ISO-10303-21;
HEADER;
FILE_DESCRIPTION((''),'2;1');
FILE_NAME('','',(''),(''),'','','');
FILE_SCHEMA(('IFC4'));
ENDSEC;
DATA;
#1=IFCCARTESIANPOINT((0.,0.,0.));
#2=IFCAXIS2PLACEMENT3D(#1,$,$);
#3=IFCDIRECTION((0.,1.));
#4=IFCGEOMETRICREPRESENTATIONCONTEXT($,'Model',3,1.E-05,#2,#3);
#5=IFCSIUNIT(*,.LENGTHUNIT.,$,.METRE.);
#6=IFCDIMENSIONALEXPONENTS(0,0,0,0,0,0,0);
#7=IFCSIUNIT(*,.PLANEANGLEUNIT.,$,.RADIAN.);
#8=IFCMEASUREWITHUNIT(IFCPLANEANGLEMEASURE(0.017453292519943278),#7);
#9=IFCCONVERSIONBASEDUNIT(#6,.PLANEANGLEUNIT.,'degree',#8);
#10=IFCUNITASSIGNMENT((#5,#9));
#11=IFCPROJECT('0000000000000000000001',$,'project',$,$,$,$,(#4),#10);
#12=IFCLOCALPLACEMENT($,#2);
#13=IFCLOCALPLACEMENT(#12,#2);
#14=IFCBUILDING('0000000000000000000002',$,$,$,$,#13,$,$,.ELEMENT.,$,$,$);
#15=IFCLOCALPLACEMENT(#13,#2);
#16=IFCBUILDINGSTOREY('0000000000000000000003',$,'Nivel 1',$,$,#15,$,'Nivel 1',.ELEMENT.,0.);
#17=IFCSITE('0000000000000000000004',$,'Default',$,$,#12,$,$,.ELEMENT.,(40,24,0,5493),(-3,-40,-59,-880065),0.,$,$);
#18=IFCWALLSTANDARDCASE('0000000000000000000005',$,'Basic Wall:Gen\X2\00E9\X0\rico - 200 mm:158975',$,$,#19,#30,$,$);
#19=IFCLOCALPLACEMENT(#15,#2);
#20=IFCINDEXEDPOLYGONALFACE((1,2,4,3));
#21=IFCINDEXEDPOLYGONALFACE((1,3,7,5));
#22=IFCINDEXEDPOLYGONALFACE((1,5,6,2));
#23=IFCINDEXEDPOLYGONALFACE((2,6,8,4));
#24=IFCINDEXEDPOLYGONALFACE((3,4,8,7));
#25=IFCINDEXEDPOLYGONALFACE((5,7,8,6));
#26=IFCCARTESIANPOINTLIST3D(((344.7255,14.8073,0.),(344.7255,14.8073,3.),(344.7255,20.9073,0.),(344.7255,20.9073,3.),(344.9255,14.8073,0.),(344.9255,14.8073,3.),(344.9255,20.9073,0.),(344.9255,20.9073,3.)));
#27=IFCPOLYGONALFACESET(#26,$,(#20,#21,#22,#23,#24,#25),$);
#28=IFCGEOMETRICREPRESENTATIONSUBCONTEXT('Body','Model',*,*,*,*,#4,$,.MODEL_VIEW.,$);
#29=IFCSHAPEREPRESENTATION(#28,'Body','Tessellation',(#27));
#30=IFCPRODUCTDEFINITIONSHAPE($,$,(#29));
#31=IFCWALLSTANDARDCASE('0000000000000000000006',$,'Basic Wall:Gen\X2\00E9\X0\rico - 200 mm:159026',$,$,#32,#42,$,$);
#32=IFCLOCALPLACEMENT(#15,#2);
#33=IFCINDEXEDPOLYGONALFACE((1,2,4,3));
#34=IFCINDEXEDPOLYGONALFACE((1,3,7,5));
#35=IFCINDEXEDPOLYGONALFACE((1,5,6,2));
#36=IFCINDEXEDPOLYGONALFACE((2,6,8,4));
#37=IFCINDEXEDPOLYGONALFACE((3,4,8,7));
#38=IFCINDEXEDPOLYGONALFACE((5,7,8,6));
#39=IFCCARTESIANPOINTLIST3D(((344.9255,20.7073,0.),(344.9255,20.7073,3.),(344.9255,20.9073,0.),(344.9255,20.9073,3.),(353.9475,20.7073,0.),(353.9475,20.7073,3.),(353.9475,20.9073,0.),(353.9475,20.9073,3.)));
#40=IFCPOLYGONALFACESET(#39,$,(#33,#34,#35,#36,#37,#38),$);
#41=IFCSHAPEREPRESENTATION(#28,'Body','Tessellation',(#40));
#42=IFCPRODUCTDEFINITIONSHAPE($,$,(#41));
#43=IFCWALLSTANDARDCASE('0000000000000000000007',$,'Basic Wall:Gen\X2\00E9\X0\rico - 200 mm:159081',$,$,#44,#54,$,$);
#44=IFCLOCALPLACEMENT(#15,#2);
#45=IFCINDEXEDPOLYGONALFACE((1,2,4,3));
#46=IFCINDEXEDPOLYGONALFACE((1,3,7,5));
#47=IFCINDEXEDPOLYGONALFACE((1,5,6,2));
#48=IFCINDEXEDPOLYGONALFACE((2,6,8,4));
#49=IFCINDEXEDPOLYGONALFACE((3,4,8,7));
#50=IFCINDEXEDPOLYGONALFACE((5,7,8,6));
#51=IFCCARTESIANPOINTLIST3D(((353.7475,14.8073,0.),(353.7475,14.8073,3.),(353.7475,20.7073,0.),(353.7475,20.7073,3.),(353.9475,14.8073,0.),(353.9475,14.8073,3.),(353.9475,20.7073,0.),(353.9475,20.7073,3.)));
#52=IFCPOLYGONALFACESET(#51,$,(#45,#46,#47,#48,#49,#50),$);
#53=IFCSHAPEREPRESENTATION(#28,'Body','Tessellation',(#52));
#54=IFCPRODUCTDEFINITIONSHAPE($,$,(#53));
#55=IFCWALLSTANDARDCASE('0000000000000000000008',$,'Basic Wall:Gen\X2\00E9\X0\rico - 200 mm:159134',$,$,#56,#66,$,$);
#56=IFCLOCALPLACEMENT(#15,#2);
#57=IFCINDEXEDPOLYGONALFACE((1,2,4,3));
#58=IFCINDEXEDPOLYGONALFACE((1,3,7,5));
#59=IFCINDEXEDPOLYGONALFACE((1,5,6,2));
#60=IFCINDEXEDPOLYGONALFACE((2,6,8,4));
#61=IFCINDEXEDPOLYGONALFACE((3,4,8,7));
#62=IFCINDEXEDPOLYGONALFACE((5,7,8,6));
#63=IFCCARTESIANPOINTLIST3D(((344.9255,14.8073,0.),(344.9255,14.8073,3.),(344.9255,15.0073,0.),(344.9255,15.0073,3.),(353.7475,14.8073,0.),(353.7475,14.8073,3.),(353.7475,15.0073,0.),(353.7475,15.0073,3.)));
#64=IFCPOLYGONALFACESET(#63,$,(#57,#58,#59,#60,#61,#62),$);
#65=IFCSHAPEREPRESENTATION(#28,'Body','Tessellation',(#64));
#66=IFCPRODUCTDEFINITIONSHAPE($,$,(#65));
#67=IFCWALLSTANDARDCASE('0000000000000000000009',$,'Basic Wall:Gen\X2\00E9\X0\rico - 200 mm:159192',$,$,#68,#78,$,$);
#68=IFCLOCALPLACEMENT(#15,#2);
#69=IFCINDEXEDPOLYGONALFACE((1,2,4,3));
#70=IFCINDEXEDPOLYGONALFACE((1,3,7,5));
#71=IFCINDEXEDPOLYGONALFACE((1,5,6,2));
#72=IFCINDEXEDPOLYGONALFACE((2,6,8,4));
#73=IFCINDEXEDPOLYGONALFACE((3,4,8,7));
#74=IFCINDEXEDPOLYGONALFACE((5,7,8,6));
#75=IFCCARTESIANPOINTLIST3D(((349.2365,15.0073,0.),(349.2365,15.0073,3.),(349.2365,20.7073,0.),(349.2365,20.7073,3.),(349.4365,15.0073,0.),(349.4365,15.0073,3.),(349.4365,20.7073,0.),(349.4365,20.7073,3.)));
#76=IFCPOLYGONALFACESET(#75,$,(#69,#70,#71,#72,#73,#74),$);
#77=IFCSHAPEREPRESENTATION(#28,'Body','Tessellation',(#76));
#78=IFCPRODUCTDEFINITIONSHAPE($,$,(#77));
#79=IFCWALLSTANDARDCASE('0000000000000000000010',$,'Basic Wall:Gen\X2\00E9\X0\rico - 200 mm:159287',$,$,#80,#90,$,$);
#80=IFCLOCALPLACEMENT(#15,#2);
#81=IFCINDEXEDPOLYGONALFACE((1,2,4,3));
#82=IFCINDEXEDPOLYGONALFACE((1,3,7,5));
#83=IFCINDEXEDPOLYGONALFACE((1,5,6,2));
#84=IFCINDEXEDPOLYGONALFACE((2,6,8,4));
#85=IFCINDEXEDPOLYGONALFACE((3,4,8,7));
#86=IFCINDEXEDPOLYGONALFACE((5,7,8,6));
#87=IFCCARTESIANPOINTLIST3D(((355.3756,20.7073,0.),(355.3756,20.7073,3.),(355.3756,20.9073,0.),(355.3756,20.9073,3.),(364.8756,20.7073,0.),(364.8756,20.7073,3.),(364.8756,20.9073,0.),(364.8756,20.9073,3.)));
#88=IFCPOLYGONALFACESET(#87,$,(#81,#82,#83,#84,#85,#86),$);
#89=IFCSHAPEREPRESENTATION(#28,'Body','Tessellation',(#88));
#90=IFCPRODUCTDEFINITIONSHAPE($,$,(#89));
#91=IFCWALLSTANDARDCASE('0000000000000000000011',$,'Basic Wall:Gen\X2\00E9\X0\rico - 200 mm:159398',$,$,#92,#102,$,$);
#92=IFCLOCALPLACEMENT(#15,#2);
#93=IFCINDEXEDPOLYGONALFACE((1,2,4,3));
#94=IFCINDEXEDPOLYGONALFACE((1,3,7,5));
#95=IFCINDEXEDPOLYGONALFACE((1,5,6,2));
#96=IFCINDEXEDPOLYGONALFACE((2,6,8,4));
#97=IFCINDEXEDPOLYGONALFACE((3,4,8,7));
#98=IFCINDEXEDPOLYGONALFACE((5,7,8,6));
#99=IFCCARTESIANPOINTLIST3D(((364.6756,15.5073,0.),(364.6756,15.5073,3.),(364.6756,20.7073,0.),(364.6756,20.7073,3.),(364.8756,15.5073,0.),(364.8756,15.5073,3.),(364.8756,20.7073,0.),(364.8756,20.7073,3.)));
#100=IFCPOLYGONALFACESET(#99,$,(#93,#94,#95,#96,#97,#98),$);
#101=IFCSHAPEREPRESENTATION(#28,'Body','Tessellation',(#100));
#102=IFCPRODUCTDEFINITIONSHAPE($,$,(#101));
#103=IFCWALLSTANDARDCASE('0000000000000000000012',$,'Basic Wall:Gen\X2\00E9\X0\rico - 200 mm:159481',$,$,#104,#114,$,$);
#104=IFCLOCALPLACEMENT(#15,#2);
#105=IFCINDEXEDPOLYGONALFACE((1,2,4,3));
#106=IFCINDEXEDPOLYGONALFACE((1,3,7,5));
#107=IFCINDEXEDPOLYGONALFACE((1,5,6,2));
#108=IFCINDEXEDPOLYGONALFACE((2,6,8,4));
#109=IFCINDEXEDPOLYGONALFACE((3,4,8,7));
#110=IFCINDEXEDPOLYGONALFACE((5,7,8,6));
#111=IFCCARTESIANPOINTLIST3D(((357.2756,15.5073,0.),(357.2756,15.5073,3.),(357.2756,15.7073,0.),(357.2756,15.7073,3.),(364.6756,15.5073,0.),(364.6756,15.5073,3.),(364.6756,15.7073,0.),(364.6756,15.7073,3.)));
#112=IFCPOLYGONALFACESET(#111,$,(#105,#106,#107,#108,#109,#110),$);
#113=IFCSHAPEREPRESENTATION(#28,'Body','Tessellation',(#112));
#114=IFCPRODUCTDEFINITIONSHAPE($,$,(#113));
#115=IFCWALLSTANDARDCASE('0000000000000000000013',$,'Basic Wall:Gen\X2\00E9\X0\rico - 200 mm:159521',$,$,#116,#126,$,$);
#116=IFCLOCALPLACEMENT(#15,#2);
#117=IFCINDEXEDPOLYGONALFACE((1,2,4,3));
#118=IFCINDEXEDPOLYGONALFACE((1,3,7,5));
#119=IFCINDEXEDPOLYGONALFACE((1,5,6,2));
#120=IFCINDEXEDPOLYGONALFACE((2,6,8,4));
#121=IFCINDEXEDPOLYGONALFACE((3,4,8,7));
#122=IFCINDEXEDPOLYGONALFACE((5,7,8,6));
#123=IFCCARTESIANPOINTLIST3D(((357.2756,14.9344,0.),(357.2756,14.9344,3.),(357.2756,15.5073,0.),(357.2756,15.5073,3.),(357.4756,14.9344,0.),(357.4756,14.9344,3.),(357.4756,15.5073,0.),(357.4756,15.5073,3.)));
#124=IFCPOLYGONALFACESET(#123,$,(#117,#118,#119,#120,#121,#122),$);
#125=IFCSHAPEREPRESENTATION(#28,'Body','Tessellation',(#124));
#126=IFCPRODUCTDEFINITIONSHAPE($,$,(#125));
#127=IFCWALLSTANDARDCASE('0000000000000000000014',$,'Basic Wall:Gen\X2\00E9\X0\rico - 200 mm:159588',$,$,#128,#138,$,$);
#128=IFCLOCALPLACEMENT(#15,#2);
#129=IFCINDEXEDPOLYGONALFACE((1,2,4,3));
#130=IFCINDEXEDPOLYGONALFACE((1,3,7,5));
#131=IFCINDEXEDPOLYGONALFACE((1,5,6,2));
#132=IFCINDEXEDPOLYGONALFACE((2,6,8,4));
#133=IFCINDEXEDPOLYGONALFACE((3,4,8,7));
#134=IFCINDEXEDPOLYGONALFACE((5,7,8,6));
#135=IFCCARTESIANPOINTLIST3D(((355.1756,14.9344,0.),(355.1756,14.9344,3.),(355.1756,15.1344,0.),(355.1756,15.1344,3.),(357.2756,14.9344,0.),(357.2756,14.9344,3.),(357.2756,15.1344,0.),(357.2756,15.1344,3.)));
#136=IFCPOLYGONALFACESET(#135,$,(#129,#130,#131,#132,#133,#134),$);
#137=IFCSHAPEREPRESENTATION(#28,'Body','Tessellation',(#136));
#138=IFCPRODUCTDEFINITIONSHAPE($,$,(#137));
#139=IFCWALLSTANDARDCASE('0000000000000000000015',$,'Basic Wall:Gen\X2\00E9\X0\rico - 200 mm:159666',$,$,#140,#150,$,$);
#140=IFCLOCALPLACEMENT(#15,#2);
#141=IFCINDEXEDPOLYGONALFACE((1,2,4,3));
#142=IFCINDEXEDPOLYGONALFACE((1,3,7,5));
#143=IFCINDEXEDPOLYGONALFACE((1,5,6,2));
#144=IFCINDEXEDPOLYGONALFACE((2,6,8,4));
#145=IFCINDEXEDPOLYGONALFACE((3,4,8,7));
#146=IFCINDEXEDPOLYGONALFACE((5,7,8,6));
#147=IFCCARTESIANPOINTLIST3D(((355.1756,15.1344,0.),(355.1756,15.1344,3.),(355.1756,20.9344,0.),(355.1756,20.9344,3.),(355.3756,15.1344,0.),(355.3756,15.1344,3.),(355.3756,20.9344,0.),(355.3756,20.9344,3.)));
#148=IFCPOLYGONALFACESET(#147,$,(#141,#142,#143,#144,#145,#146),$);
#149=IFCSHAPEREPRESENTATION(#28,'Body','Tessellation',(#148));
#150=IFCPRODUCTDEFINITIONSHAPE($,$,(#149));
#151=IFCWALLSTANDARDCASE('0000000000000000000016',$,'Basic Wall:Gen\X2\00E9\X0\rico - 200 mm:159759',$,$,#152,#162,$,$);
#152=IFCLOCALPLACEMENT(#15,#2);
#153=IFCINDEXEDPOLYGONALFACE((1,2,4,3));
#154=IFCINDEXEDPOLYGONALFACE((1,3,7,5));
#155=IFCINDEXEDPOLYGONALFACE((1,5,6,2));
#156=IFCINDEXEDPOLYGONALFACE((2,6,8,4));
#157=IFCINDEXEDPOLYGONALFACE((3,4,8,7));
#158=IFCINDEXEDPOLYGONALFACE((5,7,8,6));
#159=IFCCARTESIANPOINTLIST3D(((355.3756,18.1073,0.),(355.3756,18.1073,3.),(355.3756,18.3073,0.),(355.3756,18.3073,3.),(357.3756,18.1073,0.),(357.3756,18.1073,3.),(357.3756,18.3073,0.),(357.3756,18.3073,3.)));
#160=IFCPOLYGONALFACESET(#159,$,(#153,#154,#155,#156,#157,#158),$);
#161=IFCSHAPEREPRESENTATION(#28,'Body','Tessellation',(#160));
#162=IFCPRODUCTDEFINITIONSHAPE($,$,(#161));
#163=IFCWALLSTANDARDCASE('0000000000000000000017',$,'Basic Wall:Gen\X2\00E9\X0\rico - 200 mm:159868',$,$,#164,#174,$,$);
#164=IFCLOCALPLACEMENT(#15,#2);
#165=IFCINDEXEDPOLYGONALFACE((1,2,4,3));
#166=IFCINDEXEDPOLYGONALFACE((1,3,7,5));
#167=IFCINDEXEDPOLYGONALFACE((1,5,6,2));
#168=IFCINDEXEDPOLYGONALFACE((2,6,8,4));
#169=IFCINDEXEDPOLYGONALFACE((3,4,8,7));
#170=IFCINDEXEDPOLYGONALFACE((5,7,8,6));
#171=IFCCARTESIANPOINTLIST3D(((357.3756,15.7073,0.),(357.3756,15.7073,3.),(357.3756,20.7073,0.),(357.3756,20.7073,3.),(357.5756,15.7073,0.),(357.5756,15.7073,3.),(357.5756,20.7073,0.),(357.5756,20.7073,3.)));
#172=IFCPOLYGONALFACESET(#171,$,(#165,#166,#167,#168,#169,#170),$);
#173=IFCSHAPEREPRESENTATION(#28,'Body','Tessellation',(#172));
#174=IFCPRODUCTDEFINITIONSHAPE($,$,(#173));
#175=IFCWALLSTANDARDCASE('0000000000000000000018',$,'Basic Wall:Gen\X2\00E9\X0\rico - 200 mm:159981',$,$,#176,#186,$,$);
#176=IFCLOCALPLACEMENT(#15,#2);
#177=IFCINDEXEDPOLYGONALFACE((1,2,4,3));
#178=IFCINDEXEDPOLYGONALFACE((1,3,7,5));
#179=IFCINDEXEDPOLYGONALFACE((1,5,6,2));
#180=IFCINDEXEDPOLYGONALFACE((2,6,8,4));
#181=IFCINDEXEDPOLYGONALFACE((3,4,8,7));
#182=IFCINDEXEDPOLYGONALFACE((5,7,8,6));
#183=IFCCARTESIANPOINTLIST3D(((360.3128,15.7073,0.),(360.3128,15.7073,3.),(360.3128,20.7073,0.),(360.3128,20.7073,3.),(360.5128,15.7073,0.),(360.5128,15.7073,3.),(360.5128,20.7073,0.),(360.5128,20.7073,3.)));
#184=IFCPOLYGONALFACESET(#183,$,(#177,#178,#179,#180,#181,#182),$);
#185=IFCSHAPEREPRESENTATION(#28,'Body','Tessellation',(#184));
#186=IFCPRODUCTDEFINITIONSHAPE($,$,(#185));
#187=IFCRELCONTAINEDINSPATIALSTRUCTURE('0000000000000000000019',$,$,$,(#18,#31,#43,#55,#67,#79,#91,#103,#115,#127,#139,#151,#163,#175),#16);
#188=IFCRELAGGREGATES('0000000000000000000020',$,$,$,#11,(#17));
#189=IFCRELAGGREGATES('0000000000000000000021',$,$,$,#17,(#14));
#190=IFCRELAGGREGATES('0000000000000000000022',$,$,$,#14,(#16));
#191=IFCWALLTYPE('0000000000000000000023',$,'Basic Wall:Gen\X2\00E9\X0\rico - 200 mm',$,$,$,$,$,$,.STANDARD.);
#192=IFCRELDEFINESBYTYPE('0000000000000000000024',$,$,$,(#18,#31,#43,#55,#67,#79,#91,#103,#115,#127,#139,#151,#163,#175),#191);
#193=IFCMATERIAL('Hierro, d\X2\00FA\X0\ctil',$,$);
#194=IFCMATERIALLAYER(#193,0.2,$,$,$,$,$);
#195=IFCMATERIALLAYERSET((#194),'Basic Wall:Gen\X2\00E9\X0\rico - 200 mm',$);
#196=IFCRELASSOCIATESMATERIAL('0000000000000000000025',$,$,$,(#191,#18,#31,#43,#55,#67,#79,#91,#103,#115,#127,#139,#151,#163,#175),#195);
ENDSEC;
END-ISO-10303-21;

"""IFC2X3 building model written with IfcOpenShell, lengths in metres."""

from ifc_helpers import new_model, entity, si_unit, converted_unit, direction, frame, frame_2d, origin, place, context, subcontext, project, spatial, rectangle, extrude, material, layer, layer_set, layer_usage, type_object, element, save


model = new_model("IFC2X3")

# Units and contexts
model_context = context("Model", 3, precision=1e-05, world=origin(), true_north=direction((0.0, 1.0)))
body_context = subcontext(model_context, "Body", "Model", "MODEL_VIEW")
ifc_project = project(units=[si_unit("LENGTHUNIT", "METRE"), converted_unit("PLANEANGLEUNIT", "degree", entity("IfcPlaneAngleMeasure", 0.017453292519943278), si_unit("PLANEANGLEUNIT", "RADIAN"), dimensions=[0, 0, 0, 0, 0, 0, 0])], contexts=[model_context])

# Site, building, storey
site_placement = place(None, origin())
site = spatial("IfcSite", under=ifc_project, at=site_placement, Name="Default", CompositionType="ELEMENT", RefLatitude=(40, 24, 0, 5493), RefLongitude=(-3, -40, -59, -880065), RefElevation=0.0)
building_placement = place(site_placement, origin())
building = spatial("IfcBuilding", under=site, at=building_placement, CompositionType="ELEMENT")
storey_placement = place(building_placement, origin())
storey = spatial("IfcBuildingStorey", under=building, at=storey_placement, Name="Nivel 1", LongName="Nivel 1", CompositionType="ELEMENT", Elevation=0.0)

# Walls
ifc_material_1 = material(Name="Hierro, dúctil")
ifc_layer_1 = layer(ifc_material_1, 0.2)
ifc_layer_set_1 = layer_set([ifc_layer_1], Name="Basic Wall:Genérico - 200 mm")
ifc_layer_usage_1 = layer_usage(ifc_layer_set_1, "AXIS2", "NEGATIVE", 0.1)
wall_type = type_object("IfcWallType", Name="Basic Wall:Genérico - 200 mm", PredefinedType="STANDARD", material=ifc_layer_set_1)
wall_1_placement = place(storey_placement, frame((344.8255, 14.8073, 0.0), z_axis=(0.0, 0.0, 1.0), x_axis=(0.0, 1.0, 0.0)))
element("IfcWallStandardCase", 1, at=wall_1_placement, inside=storey, type_object=wall_type, material=ifc_layer_usage_1, Name="Basic Wall:Genérico - 200 mm:158975", context=body_context, shape_type="SweptSolid", body=[
    extrude(rectangle(XDim=6.1, YDim=0.2, at=frame_2d((3.05, 0.0), x_axis=(-1.0, 0.0))), origin(), (0.0, 0.0, 1.0), 3.0),
])
ifc_layer_usage_2 = layer_usage(ifc_layer_set_1, "AXIS2", "NEGATIVE", 0.1)
wall_2_placement = place(storey_placement, frame((344.9255, 20.8073, 0.0)))
element("IfcWallStandardCase", 2, at=wall_2_placement, inside=storey, type_object=wall_type, material=ifc_layer_usage_2, Name="Basic Wall:Genérico - 200 mm:159026", context=body_context, shape_type="SweptSolid", body=[
    extrude(rectangle(XDim=9.022, YDim=0.2, at=frame_2d((4.511, 0.0), x_axis=(-1.0, 0.0))), origin(), (0.0, 0.0, 1.0), 3.0),
])
ifc_layer_usage_3 = layer_usage(ifc_layer_set_1, "AXIS2", "NEGATIVE", 0.1)
wall_3_placement = place(storey_placement, frame((353.8475, 20.7073, 0.0), z_axis=(0.0, 0.0, 1.0), x_axis=(0.0, -1.0, 0.0)))
element("IfcWallStandardCase", 3, at=wall_3_placement, inside=storey, type_object=wall_type, material=ifc_layer_usage_3, Name="Basic Wall:Genérico - 200 mm:159081", context=body_context, shape_type="SweptSolid", body=[
    extrude(rectangle(XDim=5.9, YDim=0.2, at=frame_2d((2.95, 0.0), x_axis=(-1.0, 0.0))), origin(), (0.0, 0.0, 1.0), 3.0),
])
ifc_layer_usage_4 = layer_usage(ifc_layer_set_1, "AXIS2", "NEGATIVE", 0.1)
wall_4_placement = place(storey_placement, frame((353.7475, 14.9073, 0.0), z_axis=(0.0, 0.0, 1.0), x_axis=(-1.0, 0.0, 0.0)))
element("IfcWallStandardCase", 4, at=wall_4_placement, inside=storey, type_object=wall_type, material=ifc_layer_usage_4, Name="Basic Wall:Genérico - 200 mm:159134", context=body_context, shape_type="SweptSolid", body=[
    extrude(rectangle(XDim=8.822, YDim=0.2, at=frame_2d((4.411, 0.0), x_axis=(-1.0, 0.0))), origin(), (0.0, 0.0, 1.0), 3.0),
])
ifc_layer_usage_5 = layer_usage(ifc_layer_set_1, "AXIS2", "NEGATIVE", 0.1)
wall_5_placement = place(storey_placement, frame((349.3365, 15.0073, 0.0), z_axis=(0.0, 0.0, 1.0), x_axis=(0.0, 1.0, 0.0)))
element("IfcWallStandardCase", 5, at=wall_5_placement, inside=storey, type_object=wall_type, material=ifc_layer_usage_5, Name="Basic Wall:Genérico - 200 mm:159192", context=body_context, shape_type="SweptSolid", body=[
    extrude(rectangle(XDim=5.7, YDim=0.2, at=frame_2d((2.85, 0.0), x_axis=(-1.0, 0.0))), origin(), (0.0, 0.0, 1.0), 3.0),
])
ifc_layer_usage_6 = layer_usage(ifc_layer_set_1, "AXIS2", "NEGATIVE", 0.1)
wall_6_placement = place(storey_placement, frame((355.3756, 20.8073, 0.0)))
element("IfcWallStandardCase", 6, at=wall_6_placement, inside=storey, type_object=wall_type, material=ifc_layer_usage_6, Name="Basic Wall:Genérico - 200 mm:159287", context=body_context, shape_type="SweptSolid", body=[
    extrude(rectangle(XDim=9.5, YDim=0.2, at=frame_2d((4.75, 0.0), x_axis=(-1.0, 0.0))), origin(), (0.0, 0.0, 1.0), 3.0),
])
ifc_layer_usage_7 = layer_usage(ifc_layer_set_1, "AXIS2", "NEGATIVE", 0.1)
wall_7_placement = place(storey_placement, frame((364.7756, 20.7073, 0.0), z_axis=(0.0, 0.0, 1.0), x_axis=(0.0, -1.0, 0.0)))
element("IfcWallStandardCase", 7, at=wall_7_placement, inside=storey, type_object=wall_type, material=ifc_layer_usage_7, Name="Basic Wall:Genérico - 200 mm:159398", context=body_context, shape_type="SweptSolid", body=[
    extrude(rectangle(XDim=5.2, YDim=0.2, at=frame_2d((2.6, 0.0), x_axis=(-1.0, 0.0))), origin(), (0.0, 0.0, 1.0), 3.0),
])
ifc_layer_usage_8 = layer_usage(ifc_layer_set_1, "AXIS2", "NEGATIVE", 0.1)
wall_8_placement = place(storey_placement, frame((364.6756, 15.6073, 0.0), z_axis=(0.0, 0.0, 1.0), x_axis=(-1.0, 0.0, 0.0)))
element("IfcWallStandardCase", 8, at=wall_8_placement, inside=storey, type_object=wall_type, material=ifc_layer_usage_8, Name="Basic Wall:Genérico - 200 mm:159481", context=body_context, shape_type="SweptSolid", body=[
    extrude(rectangle(XDim=7.4, YDim=0.2, at=frame_2d((3.7, 0.0), x_axis=(-1.0, 0.0))), origin(), (0.0, 0.0, 1.0), 3.0),
])
ifc_layer_usage_9 = layer_usage(ifc_layer_set_1, "AXIS2", "NEGATIVE", 0.1)
wall_9_placement = place(storey_placement, frame((357.3756, 15.5073, 0.0), z_axis=(0.0, 0.0, 1.0), x_axis=(0.0, -1.0, 0.0)))
element("IfcWallStandardCase", 9, at=wall_9_placement, inside=storey, type_object=wall_type, material=ifc_layer_usage_9, Name="Basic Wall:Genérico - 200 mm:159521", context=body_context, shape_type="SweptSolid", body=[
    extrude(rectangle(XDim=0.5729, YDim=0.2, at=frame_2d((0.2865, 0.0), x_axis=(-1.0, 0.0))), origin(), (0.0, 0.0, 1.0), 3.0),
])
ifc_layer_usage_10 = layer_usage(ifc_layer_set_1, "AXIS2", "NEGATIVE", 0.1)
wall_10_placement = place(storey_placement, frame((357.2756, 15.0344, 0.0), z_axis=(0.0, 0.0, 1.0), x_axis=(-1.0, 0.0, 0.0)))
element("IfcWallStandardCase", 10, at=wall_10_placement, inside=storey, type_object=wall_type, material=ifc_layer_usage_10, Name="Basic Wall:Genérico - 200 mm:159588", context=body_context, shape_type="SweptSolid", body=[
    extrude(rectangle(XDim=2.1, YDim=0.2, at=frame_2d((1.05, 0.0), x_axis=(-1.0, 0.0))), origin(), (0.0, 0.0, 1.0), 3.0),
])
ifc_layer_usage_11 = layer_usage(ifc_layer_set_1, "AXIS2", "NEGATIVE", 0.1)
wall_11_placement = place(storey_placement, frame((355.2756, 15.1344, 0.0), z_axis=(0.0, 0.0, 1.0), x_axis=(0.0, 1.0, 0.0)))
element("IfcWallStandardCase", 11, at=wall_11_placement, inside=storey, type_object=wall_type, material=ifc_layer_usage_11, Name="Basic Wall:Genérico - 200 mm:159666", context=body_context, shape_type="SweptSolid", body=[
    extrude(rectangle(XDim=5.8, YDim=0.2, at=frame_2d((2.9, 0.0), x_axis=(-1.0, 0.0))), origin(), (0.0, 0.0, 1.0), 3.0),
])
ifc_layer_usage_12 = layer_usage(ifc_layer_set_1, "AXIS2", "NEGATIVE", 0.1)
wall_12_placement = place(storey_placement, frame((355.3756, 18.2073, 0.0)))
element("IfcWallStandardCase", 12, at=wall_12_placement, inside=storey, type_object=wall_type, material=ifc_layer_usage_12, Name="Basic Wall:Genérico - 200 mm:159759", context=body_context, shape_type="SweptSolid", body=[
    extrude(rectangle(XDim=2.0, YDim=0.2, at=frame_2d((1.0, 0.0), x_axis=(-1.0, 0.0))), origin(), (0.0, 0.0, 1.0), 3.0),
])
ifc_layer_usage_13 = layer_usage(ifc_layer_set_1, "AXIS2", "NEGATIVE", 0.1)
wall_13_placement = place(storey_placement, frame((357.4756, 20.7073, 0.0), z_axis=(0.0, 0.0, 1.0), x_axis=(0.0, -1.0, 0.0)))
element("IfcWallStandardCase", 13, at=wall_13_placement, inside=storey, type_object=wall_type, material=ifc_layer_usage_13, Name="Basic Wall:Genérico - 200 mm:159868", context=body_context, shape_type="SweptSolid", body=[
    extrude(rectangle(XDim=5.0, YDim=0.2, at=frame_2d((2.5, 0.0), x_axis=(-1.0, 0.0))), origin(), (0.0, 0.0, 1.0), 3.0),
])
ifc_layer_usage_14 = layer_usage(ifc_layer_set_1, "AXIS2", "NEGATIVE", 0.1)
wall_14_placement = place(storey_placement, frame((360.4128, 15.7073, 0.0), z_axis=(0.0, 0.0, 1.0), x_axis=(0.0, 1.0, 0.0)))
element("IfcWallStandardCase", 14, at=wall_14_placement, inside=storey, type_object=wall_type, material=ifc_layer_usage_14, Name="Basic Wall:Genérico - 200 mm:159981", context=body_context, shape_type="SweptSolid", body=[
    extrude(rectangle(XDim=5.0, YDim=0.2, at=frame_2d((2.5, 0.0), x_axis=(-1.0, 0.0))), origin(), (0.0, 0.0, 1.0), 3.0),
])

save(model, "model.ifc")
